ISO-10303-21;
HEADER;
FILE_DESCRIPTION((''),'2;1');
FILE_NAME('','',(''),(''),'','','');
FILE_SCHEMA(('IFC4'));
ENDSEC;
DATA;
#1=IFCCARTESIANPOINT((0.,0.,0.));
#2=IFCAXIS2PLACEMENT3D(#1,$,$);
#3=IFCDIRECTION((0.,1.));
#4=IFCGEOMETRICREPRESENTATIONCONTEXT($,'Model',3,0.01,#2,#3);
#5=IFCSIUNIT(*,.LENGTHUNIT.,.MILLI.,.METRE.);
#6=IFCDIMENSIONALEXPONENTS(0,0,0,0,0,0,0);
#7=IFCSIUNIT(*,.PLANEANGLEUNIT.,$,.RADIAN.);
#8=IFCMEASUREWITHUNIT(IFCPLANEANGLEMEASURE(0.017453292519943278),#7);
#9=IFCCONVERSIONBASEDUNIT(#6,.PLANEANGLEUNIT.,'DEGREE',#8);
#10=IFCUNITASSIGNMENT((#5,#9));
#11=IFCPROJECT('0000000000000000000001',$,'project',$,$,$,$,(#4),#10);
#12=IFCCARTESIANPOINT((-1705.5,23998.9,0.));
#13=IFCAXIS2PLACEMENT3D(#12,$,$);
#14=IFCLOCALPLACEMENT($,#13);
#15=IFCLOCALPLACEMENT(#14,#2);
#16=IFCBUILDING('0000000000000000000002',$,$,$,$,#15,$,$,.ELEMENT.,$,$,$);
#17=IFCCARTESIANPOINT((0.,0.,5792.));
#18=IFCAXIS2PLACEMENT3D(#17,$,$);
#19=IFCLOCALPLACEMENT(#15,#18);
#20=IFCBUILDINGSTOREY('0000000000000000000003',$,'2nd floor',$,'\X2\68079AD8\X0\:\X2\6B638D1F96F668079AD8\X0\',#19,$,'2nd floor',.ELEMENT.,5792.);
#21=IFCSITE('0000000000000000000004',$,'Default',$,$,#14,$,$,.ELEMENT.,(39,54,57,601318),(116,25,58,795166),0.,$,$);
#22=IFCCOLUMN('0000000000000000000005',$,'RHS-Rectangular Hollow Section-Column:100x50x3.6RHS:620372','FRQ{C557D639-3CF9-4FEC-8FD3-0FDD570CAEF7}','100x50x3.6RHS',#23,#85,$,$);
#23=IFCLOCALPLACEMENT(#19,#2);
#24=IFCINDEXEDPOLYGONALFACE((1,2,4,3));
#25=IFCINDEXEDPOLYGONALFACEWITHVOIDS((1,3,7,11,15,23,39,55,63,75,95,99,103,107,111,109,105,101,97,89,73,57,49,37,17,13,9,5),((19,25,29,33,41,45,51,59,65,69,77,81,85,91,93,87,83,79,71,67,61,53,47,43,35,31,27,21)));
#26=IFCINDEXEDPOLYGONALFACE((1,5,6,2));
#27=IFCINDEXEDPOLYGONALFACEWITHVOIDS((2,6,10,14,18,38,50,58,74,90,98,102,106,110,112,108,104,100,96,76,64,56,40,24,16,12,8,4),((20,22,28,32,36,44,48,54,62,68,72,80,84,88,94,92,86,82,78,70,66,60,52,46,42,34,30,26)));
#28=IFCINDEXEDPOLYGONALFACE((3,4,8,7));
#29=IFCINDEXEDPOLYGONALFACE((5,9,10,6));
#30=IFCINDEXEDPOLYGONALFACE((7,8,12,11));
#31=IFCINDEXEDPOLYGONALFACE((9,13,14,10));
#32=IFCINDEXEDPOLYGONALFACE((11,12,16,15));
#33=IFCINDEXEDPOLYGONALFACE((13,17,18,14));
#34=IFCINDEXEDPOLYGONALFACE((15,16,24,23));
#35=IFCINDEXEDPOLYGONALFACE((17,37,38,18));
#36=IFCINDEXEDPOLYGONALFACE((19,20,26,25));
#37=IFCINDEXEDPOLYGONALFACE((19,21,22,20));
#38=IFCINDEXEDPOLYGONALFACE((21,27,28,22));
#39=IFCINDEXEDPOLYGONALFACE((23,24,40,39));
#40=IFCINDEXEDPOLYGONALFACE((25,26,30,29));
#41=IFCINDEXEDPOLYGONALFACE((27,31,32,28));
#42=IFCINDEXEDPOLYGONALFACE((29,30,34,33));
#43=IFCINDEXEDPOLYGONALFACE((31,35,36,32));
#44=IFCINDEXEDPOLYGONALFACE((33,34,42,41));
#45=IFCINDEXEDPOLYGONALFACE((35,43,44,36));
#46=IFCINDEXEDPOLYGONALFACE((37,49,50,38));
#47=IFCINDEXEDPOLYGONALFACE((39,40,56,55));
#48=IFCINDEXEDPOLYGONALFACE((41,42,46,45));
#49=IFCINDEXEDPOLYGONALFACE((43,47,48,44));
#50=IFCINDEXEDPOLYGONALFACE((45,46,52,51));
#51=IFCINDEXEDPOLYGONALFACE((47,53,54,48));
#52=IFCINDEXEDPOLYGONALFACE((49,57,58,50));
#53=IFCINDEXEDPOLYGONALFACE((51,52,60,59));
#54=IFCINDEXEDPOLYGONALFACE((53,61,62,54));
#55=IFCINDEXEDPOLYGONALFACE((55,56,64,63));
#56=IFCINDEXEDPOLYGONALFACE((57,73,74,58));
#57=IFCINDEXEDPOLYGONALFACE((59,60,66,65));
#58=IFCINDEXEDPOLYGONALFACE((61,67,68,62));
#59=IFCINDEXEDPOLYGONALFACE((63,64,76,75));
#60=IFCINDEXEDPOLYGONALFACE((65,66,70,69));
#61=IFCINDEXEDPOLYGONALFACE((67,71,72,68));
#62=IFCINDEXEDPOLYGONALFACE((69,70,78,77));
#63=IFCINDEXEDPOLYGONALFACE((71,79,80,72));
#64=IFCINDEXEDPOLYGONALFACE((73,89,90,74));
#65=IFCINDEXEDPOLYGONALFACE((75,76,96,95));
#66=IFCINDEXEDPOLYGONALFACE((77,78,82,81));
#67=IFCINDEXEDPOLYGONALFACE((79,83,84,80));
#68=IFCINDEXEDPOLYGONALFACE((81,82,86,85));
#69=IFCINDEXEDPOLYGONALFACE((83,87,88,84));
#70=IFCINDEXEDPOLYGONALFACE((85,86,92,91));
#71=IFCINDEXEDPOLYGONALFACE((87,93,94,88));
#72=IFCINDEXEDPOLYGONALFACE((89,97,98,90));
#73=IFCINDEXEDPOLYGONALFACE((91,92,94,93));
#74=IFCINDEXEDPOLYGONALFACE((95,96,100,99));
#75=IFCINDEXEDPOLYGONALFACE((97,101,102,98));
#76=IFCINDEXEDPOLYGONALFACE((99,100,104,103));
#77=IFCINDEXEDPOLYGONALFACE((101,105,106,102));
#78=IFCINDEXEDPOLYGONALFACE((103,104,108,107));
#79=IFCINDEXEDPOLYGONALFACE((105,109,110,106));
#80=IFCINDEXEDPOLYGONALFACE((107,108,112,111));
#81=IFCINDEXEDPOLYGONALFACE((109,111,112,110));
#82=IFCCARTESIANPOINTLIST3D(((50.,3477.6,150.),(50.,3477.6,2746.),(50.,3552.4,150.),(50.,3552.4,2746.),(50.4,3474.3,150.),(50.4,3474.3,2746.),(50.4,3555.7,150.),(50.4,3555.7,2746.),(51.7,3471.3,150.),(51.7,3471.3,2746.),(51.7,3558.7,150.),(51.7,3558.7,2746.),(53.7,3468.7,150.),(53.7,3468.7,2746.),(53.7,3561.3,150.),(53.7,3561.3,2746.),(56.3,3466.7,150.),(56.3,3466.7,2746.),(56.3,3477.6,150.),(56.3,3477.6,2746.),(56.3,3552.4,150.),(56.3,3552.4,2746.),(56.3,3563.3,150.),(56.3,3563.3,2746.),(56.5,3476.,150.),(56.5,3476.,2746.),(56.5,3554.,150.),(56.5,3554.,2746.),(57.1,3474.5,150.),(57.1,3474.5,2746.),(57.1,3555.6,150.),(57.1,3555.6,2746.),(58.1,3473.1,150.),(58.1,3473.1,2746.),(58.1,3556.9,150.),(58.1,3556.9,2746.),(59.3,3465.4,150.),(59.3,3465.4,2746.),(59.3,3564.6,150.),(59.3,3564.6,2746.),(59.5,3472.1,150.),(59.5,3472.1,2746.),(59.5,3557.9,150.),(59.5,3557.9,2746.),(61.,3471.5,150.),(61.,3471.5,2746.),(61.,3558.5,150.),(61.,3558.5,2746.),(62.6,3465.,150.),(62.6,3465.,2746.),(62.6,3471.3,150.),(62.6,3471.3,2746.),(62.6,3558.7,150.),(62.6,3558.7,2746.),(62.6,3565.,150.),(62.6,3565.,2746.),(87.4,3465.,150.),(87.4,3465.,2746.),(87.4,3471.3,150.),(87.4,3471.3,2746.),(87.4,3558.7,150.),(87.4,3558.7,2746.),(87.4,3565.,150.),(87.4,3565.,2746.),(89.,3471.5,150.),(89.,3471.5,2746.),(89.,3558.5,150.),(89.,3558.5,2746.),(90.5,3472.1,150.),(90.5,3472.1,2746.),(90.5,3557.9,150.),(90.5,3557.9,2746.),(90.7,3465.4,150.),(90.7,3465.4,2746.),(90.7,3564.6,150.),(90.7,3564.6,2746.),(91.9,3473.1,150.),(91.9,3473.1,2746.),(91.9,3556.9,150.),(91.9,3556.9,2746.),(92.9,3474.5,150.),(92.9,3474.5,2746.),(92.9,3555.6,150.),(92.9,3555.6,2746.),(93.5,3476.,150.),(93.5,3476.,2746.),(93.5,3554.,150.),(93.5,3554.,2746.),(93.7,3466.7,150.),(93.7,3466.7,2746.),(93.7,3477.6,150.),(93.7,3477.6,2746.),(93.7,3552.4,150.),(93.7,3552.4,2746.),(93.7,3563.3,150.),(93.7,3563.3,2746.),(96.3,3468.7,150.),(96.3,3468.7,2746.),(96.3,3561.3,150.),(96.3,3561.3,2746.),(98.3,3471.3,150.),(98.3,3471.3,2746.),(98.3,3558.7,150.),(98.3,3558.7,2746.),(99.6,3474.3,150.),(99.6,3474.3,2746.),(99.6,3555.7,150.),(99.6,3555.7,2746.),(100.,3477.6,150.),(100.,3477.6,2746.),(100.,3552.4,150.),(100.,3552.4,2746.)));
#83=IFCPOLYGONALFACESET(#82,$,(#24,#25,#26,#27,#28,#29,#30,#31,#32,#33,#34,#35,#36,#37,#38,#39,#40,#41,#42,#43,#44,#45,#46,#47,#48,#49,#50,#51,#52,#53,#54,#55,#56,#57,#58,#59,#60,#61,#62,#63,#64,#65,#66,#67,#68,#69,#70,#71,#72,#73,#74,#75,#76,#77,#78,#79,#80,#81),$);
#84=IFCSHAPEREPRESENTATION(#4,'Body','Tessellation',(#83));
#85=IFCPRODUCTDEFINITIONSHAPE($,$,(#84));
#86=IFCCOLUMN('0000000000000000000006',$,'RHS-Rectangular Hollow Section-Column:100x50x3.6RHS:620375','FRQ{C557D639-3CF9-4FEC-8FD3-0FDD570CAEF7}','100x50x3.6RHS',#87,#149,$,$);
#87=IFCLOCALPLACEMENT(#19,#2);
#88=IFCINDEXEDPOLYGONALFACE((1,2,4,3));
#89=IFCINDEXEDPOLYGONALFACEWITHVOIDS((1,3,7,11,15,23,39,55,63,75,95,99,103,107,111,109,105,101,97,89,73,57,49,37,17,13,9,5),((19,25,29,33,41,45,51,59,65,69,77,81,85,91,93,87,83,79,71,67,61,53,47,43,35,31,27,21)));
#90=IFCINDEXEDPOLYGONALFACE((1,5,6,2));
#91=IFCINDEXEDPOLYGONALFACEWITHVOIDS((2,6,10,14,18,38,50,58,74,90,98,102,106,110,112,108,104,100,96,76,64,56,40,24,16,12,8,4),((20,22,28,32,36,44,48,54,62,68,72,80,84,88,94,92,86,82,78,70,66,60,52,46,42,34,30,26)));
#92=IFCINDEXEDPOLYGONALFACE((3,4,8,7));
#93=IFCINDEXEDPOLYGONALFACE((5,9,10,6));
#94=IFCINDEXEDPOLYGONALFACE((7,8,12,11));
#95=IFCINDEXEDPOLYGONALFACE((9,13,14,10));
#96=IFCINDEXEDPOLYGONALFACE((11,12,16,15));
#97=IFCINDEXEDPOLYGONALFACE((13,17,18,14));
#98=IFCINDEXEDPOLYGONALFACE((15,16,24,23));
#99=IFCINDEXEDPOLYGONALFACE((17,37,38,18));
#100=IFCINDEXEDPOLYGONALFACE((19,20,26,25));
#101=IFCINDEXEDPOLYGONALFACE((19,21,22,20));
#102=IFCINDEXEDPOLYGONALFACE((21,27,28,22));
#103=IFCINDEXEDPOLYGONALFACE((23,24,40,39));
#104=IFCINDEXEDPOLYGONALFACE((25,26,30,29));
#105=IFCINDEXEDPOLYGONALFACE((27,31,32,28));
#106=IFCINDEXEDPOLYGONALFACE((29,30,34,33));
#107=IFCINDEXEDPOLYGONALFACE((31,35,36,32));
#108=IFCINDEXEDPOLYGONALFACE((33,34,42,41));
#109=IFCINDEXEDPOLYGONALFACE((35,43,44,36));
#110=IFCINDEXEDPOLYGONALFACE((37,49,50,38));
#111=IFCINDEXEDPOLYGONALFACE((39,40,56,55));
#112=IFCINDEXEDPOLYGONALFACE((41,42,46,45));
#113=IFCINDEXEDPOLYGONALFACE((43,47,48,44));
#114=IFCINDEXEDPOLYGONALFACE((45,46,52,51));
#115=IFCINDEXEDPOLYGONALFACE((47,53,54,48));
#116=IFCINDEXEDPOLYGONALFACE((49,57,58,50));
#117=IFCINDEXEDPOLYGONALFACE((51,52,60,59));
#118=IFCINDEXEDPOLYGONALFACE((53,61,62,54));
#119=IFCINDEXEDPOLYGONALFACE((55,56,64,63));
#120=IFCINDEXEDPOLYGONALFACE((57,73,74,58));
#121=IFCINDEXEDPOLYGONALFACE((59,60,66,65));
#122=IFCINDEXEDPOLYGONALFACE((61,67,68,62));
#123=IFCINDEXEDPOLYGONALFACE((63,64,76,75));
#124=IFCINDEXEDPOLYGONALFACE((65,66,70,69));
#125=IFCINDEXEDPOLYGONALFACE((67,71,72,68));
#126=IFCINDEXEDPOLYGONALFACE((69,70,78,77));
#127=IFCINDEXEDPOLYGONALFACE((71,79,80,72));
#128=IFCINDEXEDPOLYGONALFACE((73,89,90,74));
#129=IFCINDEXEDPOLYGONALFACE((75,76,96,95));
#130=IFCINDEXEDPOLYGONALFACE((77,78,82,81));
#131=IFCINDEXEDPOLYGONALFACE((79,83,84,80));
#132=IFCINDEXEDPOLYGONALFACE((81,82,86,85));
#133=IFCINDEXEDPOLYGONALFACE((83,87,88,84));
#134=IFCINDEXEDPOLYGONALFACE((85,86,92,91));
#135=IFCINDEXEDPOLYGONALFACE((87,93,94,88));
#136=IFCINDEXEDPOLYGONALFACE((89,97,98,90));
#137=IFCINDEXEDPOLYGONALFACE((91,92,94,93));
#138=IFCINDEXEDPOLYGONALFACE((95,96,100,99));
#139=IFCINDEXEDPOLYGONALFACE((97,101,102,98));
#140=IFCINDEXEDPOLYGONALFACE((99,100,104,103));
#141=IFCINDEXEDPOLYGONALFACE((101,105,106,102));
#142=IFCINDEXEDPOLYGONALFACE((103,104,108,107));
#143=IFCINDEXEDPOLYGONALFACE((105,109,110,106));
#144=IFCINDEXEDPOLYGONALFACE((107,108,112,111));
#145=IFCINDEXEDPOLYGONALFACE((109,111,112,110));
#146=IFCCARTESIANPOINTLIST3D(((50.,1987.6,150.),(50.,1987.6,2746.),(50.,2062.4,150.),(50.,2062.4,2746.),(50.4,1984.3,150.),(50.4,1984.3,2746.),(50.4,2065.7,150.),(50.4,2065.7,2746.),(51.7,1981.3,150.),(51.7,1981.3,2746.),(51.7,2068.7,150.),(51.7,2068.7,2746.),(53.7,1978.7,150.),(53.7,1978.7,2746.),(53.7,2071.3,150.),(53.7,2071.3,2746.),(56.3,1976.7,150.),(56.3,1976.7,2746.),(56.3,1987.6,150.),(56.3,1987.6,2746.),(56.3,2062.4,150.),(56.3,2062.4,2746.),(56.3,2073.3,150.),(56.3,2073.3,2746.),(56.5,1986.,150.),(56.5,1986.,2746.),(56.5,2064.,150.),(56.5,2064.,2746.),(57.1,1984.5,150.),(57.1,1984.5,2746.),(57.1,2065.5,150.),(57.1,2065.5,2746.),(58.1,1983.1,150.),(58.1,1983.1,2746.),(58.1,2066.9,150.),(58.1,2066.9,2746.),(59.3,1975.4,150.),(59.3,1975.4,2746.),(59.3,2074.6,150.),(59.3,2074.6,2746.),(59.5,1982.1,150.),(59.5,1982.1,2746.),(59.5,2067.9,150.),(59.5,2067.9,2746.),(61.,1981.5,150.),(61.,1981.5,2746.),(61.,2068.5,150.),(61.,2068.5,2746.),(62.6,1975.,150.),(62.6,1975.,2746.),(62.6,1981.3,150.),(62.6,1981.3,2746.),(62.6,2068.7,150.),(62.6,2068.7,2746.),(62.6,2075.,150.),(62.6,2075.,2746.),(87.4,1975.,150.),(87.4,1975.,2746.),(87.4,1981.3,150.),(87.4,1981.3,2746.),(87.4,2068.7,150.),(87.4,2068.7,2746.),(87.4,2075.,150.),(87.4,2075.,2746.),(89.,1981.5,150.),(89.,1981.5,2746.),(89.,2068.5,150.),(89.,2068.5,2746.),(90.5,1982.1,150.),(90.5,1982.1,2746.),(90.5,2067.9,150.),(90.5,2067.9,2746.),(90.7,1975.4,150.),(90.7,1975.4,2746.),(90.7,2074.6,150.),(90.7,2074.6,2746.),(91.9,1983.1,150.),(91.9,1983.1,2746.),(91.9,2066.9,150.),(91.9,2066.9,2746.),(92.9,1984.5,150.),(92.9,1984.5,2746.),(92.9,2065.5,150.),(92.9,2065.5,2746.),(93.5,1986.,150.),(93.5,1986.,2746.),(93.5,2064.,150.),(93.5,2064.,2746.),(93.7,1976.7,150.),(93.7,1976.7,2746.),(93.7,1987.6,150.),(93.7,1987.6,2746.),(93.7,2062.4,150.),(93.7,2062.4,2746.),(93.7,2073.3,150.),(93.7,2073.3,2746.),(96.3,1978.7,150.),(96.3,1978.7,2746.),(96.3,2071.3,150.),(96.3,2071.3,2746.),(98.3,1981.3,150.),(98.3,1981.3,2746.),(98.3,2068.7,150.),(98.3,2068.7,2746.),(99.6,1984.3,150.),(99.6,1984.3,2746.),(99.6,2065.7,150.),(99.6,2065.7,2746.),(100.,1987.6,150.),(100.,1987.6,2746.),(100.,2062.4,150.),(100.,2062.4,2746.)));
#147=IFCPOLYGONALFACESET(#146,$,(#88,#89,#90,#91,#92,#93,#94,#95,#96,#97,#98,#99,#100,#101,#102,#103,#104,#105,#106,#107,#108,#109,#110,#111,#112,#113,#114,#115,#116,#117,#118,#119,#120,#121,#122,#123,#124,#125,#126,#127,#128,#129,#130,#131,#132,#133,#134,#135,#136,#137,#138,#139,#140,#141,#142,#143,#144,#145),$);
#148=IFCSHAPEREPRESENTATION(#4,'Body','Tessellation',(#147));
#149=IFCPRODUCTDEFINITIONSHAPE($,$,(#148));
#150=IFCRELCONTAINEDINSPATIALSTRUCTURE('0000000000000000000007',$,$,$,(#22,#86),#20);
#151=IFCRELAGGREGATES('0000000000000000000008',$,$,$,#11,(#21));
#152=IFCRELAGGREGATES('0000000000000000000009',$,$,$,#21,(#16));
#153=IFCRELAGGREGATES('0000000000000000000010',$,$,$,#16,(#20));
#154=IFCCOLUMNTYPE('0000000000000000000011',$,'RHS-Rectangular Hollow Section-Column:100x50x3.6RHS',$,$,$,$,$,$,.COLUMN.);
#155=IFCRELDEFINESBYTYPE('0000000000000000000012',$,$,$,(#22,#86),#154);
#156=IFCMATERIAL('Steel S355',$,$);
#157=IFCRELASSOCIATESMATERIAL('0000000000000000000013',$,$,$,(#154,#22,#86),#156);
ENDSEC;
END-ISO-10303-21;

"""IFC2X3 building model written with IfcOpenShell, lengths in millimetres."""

from ifc_helpers import new_model, entity, si_unit, converted_unit, direction, frame, origin, origin_2d, place, context, project, spatial, hollow_rectangle, extrude, clip, halfspace, material, type_object, element, save


model = new_model("IFC2X3")

# Units and contexts
model_context = context("Model", 3, precision=0.01, world=origin(), true_north=direction((0.0, 1.0)))
ifc_project = project(units=[si_unit("LENGTHUNIT", "METRE", prefix="MILLI"), converted_unit("PLANEANGLEUNIT", "DEGREE", entity("IfcPlaneAngleMeasure", 0.017453292519943278), si_unit("PLANEANGLEUNIT", "RADIAN"), dimensions=[0, 0, 0, 0, 0, 0, 0])], contexts=[model_context])

# Site, building, storey
site_placement = place(None, frame((-1705.5, 23998.9, 0.0)))
site = spatial("IfcSite", under=ifc_project, at=site_placement, Name="Default", CompositionType="ELEMENT", RefLatitude=(39, 54, 57, 601318), RefLongitude=(116, 25, 58, 795166), RefElevation=0.0)
building_placement = place(site_placement, origin())
building = spatial("IfcBuilding", under=site, at=building_placement, CompositionType="ELEMENT")
storey_placement = place(building_placement, frame((0.0, 0.0, 5792.0)))
storey = spatial("IfcBuildingStorey", under=building, at=storey_placement, Name="2nd floor", ObjectType="标高:正负零标高", LongName="2nd floor", CompositionType="ELEMENT", Elevation=5792.0)

# Columns
ifc_material_1 = material(Name="Steel S355")
column_type_1 = type_object("IfcColumnType", Name="RHS-Rectangular Hollow Section-Column:100x50x3.6RHS", PredefinedType="COLUMN", material=ifc_material_1)
column_1_placement = place(storey_placement, frame((75.0, 3515.0, 2746.0), z_axis=(0.0, 0.0, 1.0), x_axis=(-1.0, 0.0, 0.0)))
element("IfcColumn", 1, at=column_1_placement, inside=storey, type_object=column_type_1, material=ifc_material_1, Name="RHS-Rectangular Hollow Section-Column:100x50x3.6RHS:620372", Description="FRQ{C557D639-3CF9-4FEC-8FD3-0FDD570CAEF7}", ObjectType="100x50x3.6RHS", context=model_context, shape_type="Clipping", body=[
    clip(extrude(hollow_rectangle(XDim=50.0, YDim=100.0, WallThickness=6.3, InnerFilletRadius=6.3, OuterFilletRadius=12.6, at=origin_2d()), origin(), (0.0, 0.0, -1.0), 2651.9), halfspace(frame((75.0, 3515.0, -2596.0), z_axis=(0.0, 0.0, 1.0), x_axis=(-1.0, 0.0, 0.0)), True)),
])
column_2_placement = place(storey_placement, frame((75.0, 2025.0, 2746.0), z_axis=(0.0, 0.0, 1.0), x_axis=(-1.0, 0.0, 0.0)))
element("IfcColumn", 2, at=column_2_placement, inside=storey, type_object=column_type_1, material=ifc_material_1, Name="RHS-Rectangular Hollow Section-Column:100x50x3.6RHS:620375", Description="FRQ{C557D639-3CF9-4FEC-8FD3-0FDD570CAEF7}", ObjectType="100x50x3.6RHS", context=model_context, shape_type="Clipping", body=[
    clip(extrude(hollow_rectangle(XDim=50.0, YDim=100.0, WallThickness=6.3, InnerFilletRadius=6.3, OuterFilletRadius=12.6, at=origin_2d()), origin(), (0.0, 0.0, -1.0), 2651.9), halfspace(frame((75.0, 2025.0, -2596.0), z_axis=(0.0, 0.0, 1.0), x_axis=(-1.0, 0.0, 0.0)), True)),
])

save(model, "model.ifc")
